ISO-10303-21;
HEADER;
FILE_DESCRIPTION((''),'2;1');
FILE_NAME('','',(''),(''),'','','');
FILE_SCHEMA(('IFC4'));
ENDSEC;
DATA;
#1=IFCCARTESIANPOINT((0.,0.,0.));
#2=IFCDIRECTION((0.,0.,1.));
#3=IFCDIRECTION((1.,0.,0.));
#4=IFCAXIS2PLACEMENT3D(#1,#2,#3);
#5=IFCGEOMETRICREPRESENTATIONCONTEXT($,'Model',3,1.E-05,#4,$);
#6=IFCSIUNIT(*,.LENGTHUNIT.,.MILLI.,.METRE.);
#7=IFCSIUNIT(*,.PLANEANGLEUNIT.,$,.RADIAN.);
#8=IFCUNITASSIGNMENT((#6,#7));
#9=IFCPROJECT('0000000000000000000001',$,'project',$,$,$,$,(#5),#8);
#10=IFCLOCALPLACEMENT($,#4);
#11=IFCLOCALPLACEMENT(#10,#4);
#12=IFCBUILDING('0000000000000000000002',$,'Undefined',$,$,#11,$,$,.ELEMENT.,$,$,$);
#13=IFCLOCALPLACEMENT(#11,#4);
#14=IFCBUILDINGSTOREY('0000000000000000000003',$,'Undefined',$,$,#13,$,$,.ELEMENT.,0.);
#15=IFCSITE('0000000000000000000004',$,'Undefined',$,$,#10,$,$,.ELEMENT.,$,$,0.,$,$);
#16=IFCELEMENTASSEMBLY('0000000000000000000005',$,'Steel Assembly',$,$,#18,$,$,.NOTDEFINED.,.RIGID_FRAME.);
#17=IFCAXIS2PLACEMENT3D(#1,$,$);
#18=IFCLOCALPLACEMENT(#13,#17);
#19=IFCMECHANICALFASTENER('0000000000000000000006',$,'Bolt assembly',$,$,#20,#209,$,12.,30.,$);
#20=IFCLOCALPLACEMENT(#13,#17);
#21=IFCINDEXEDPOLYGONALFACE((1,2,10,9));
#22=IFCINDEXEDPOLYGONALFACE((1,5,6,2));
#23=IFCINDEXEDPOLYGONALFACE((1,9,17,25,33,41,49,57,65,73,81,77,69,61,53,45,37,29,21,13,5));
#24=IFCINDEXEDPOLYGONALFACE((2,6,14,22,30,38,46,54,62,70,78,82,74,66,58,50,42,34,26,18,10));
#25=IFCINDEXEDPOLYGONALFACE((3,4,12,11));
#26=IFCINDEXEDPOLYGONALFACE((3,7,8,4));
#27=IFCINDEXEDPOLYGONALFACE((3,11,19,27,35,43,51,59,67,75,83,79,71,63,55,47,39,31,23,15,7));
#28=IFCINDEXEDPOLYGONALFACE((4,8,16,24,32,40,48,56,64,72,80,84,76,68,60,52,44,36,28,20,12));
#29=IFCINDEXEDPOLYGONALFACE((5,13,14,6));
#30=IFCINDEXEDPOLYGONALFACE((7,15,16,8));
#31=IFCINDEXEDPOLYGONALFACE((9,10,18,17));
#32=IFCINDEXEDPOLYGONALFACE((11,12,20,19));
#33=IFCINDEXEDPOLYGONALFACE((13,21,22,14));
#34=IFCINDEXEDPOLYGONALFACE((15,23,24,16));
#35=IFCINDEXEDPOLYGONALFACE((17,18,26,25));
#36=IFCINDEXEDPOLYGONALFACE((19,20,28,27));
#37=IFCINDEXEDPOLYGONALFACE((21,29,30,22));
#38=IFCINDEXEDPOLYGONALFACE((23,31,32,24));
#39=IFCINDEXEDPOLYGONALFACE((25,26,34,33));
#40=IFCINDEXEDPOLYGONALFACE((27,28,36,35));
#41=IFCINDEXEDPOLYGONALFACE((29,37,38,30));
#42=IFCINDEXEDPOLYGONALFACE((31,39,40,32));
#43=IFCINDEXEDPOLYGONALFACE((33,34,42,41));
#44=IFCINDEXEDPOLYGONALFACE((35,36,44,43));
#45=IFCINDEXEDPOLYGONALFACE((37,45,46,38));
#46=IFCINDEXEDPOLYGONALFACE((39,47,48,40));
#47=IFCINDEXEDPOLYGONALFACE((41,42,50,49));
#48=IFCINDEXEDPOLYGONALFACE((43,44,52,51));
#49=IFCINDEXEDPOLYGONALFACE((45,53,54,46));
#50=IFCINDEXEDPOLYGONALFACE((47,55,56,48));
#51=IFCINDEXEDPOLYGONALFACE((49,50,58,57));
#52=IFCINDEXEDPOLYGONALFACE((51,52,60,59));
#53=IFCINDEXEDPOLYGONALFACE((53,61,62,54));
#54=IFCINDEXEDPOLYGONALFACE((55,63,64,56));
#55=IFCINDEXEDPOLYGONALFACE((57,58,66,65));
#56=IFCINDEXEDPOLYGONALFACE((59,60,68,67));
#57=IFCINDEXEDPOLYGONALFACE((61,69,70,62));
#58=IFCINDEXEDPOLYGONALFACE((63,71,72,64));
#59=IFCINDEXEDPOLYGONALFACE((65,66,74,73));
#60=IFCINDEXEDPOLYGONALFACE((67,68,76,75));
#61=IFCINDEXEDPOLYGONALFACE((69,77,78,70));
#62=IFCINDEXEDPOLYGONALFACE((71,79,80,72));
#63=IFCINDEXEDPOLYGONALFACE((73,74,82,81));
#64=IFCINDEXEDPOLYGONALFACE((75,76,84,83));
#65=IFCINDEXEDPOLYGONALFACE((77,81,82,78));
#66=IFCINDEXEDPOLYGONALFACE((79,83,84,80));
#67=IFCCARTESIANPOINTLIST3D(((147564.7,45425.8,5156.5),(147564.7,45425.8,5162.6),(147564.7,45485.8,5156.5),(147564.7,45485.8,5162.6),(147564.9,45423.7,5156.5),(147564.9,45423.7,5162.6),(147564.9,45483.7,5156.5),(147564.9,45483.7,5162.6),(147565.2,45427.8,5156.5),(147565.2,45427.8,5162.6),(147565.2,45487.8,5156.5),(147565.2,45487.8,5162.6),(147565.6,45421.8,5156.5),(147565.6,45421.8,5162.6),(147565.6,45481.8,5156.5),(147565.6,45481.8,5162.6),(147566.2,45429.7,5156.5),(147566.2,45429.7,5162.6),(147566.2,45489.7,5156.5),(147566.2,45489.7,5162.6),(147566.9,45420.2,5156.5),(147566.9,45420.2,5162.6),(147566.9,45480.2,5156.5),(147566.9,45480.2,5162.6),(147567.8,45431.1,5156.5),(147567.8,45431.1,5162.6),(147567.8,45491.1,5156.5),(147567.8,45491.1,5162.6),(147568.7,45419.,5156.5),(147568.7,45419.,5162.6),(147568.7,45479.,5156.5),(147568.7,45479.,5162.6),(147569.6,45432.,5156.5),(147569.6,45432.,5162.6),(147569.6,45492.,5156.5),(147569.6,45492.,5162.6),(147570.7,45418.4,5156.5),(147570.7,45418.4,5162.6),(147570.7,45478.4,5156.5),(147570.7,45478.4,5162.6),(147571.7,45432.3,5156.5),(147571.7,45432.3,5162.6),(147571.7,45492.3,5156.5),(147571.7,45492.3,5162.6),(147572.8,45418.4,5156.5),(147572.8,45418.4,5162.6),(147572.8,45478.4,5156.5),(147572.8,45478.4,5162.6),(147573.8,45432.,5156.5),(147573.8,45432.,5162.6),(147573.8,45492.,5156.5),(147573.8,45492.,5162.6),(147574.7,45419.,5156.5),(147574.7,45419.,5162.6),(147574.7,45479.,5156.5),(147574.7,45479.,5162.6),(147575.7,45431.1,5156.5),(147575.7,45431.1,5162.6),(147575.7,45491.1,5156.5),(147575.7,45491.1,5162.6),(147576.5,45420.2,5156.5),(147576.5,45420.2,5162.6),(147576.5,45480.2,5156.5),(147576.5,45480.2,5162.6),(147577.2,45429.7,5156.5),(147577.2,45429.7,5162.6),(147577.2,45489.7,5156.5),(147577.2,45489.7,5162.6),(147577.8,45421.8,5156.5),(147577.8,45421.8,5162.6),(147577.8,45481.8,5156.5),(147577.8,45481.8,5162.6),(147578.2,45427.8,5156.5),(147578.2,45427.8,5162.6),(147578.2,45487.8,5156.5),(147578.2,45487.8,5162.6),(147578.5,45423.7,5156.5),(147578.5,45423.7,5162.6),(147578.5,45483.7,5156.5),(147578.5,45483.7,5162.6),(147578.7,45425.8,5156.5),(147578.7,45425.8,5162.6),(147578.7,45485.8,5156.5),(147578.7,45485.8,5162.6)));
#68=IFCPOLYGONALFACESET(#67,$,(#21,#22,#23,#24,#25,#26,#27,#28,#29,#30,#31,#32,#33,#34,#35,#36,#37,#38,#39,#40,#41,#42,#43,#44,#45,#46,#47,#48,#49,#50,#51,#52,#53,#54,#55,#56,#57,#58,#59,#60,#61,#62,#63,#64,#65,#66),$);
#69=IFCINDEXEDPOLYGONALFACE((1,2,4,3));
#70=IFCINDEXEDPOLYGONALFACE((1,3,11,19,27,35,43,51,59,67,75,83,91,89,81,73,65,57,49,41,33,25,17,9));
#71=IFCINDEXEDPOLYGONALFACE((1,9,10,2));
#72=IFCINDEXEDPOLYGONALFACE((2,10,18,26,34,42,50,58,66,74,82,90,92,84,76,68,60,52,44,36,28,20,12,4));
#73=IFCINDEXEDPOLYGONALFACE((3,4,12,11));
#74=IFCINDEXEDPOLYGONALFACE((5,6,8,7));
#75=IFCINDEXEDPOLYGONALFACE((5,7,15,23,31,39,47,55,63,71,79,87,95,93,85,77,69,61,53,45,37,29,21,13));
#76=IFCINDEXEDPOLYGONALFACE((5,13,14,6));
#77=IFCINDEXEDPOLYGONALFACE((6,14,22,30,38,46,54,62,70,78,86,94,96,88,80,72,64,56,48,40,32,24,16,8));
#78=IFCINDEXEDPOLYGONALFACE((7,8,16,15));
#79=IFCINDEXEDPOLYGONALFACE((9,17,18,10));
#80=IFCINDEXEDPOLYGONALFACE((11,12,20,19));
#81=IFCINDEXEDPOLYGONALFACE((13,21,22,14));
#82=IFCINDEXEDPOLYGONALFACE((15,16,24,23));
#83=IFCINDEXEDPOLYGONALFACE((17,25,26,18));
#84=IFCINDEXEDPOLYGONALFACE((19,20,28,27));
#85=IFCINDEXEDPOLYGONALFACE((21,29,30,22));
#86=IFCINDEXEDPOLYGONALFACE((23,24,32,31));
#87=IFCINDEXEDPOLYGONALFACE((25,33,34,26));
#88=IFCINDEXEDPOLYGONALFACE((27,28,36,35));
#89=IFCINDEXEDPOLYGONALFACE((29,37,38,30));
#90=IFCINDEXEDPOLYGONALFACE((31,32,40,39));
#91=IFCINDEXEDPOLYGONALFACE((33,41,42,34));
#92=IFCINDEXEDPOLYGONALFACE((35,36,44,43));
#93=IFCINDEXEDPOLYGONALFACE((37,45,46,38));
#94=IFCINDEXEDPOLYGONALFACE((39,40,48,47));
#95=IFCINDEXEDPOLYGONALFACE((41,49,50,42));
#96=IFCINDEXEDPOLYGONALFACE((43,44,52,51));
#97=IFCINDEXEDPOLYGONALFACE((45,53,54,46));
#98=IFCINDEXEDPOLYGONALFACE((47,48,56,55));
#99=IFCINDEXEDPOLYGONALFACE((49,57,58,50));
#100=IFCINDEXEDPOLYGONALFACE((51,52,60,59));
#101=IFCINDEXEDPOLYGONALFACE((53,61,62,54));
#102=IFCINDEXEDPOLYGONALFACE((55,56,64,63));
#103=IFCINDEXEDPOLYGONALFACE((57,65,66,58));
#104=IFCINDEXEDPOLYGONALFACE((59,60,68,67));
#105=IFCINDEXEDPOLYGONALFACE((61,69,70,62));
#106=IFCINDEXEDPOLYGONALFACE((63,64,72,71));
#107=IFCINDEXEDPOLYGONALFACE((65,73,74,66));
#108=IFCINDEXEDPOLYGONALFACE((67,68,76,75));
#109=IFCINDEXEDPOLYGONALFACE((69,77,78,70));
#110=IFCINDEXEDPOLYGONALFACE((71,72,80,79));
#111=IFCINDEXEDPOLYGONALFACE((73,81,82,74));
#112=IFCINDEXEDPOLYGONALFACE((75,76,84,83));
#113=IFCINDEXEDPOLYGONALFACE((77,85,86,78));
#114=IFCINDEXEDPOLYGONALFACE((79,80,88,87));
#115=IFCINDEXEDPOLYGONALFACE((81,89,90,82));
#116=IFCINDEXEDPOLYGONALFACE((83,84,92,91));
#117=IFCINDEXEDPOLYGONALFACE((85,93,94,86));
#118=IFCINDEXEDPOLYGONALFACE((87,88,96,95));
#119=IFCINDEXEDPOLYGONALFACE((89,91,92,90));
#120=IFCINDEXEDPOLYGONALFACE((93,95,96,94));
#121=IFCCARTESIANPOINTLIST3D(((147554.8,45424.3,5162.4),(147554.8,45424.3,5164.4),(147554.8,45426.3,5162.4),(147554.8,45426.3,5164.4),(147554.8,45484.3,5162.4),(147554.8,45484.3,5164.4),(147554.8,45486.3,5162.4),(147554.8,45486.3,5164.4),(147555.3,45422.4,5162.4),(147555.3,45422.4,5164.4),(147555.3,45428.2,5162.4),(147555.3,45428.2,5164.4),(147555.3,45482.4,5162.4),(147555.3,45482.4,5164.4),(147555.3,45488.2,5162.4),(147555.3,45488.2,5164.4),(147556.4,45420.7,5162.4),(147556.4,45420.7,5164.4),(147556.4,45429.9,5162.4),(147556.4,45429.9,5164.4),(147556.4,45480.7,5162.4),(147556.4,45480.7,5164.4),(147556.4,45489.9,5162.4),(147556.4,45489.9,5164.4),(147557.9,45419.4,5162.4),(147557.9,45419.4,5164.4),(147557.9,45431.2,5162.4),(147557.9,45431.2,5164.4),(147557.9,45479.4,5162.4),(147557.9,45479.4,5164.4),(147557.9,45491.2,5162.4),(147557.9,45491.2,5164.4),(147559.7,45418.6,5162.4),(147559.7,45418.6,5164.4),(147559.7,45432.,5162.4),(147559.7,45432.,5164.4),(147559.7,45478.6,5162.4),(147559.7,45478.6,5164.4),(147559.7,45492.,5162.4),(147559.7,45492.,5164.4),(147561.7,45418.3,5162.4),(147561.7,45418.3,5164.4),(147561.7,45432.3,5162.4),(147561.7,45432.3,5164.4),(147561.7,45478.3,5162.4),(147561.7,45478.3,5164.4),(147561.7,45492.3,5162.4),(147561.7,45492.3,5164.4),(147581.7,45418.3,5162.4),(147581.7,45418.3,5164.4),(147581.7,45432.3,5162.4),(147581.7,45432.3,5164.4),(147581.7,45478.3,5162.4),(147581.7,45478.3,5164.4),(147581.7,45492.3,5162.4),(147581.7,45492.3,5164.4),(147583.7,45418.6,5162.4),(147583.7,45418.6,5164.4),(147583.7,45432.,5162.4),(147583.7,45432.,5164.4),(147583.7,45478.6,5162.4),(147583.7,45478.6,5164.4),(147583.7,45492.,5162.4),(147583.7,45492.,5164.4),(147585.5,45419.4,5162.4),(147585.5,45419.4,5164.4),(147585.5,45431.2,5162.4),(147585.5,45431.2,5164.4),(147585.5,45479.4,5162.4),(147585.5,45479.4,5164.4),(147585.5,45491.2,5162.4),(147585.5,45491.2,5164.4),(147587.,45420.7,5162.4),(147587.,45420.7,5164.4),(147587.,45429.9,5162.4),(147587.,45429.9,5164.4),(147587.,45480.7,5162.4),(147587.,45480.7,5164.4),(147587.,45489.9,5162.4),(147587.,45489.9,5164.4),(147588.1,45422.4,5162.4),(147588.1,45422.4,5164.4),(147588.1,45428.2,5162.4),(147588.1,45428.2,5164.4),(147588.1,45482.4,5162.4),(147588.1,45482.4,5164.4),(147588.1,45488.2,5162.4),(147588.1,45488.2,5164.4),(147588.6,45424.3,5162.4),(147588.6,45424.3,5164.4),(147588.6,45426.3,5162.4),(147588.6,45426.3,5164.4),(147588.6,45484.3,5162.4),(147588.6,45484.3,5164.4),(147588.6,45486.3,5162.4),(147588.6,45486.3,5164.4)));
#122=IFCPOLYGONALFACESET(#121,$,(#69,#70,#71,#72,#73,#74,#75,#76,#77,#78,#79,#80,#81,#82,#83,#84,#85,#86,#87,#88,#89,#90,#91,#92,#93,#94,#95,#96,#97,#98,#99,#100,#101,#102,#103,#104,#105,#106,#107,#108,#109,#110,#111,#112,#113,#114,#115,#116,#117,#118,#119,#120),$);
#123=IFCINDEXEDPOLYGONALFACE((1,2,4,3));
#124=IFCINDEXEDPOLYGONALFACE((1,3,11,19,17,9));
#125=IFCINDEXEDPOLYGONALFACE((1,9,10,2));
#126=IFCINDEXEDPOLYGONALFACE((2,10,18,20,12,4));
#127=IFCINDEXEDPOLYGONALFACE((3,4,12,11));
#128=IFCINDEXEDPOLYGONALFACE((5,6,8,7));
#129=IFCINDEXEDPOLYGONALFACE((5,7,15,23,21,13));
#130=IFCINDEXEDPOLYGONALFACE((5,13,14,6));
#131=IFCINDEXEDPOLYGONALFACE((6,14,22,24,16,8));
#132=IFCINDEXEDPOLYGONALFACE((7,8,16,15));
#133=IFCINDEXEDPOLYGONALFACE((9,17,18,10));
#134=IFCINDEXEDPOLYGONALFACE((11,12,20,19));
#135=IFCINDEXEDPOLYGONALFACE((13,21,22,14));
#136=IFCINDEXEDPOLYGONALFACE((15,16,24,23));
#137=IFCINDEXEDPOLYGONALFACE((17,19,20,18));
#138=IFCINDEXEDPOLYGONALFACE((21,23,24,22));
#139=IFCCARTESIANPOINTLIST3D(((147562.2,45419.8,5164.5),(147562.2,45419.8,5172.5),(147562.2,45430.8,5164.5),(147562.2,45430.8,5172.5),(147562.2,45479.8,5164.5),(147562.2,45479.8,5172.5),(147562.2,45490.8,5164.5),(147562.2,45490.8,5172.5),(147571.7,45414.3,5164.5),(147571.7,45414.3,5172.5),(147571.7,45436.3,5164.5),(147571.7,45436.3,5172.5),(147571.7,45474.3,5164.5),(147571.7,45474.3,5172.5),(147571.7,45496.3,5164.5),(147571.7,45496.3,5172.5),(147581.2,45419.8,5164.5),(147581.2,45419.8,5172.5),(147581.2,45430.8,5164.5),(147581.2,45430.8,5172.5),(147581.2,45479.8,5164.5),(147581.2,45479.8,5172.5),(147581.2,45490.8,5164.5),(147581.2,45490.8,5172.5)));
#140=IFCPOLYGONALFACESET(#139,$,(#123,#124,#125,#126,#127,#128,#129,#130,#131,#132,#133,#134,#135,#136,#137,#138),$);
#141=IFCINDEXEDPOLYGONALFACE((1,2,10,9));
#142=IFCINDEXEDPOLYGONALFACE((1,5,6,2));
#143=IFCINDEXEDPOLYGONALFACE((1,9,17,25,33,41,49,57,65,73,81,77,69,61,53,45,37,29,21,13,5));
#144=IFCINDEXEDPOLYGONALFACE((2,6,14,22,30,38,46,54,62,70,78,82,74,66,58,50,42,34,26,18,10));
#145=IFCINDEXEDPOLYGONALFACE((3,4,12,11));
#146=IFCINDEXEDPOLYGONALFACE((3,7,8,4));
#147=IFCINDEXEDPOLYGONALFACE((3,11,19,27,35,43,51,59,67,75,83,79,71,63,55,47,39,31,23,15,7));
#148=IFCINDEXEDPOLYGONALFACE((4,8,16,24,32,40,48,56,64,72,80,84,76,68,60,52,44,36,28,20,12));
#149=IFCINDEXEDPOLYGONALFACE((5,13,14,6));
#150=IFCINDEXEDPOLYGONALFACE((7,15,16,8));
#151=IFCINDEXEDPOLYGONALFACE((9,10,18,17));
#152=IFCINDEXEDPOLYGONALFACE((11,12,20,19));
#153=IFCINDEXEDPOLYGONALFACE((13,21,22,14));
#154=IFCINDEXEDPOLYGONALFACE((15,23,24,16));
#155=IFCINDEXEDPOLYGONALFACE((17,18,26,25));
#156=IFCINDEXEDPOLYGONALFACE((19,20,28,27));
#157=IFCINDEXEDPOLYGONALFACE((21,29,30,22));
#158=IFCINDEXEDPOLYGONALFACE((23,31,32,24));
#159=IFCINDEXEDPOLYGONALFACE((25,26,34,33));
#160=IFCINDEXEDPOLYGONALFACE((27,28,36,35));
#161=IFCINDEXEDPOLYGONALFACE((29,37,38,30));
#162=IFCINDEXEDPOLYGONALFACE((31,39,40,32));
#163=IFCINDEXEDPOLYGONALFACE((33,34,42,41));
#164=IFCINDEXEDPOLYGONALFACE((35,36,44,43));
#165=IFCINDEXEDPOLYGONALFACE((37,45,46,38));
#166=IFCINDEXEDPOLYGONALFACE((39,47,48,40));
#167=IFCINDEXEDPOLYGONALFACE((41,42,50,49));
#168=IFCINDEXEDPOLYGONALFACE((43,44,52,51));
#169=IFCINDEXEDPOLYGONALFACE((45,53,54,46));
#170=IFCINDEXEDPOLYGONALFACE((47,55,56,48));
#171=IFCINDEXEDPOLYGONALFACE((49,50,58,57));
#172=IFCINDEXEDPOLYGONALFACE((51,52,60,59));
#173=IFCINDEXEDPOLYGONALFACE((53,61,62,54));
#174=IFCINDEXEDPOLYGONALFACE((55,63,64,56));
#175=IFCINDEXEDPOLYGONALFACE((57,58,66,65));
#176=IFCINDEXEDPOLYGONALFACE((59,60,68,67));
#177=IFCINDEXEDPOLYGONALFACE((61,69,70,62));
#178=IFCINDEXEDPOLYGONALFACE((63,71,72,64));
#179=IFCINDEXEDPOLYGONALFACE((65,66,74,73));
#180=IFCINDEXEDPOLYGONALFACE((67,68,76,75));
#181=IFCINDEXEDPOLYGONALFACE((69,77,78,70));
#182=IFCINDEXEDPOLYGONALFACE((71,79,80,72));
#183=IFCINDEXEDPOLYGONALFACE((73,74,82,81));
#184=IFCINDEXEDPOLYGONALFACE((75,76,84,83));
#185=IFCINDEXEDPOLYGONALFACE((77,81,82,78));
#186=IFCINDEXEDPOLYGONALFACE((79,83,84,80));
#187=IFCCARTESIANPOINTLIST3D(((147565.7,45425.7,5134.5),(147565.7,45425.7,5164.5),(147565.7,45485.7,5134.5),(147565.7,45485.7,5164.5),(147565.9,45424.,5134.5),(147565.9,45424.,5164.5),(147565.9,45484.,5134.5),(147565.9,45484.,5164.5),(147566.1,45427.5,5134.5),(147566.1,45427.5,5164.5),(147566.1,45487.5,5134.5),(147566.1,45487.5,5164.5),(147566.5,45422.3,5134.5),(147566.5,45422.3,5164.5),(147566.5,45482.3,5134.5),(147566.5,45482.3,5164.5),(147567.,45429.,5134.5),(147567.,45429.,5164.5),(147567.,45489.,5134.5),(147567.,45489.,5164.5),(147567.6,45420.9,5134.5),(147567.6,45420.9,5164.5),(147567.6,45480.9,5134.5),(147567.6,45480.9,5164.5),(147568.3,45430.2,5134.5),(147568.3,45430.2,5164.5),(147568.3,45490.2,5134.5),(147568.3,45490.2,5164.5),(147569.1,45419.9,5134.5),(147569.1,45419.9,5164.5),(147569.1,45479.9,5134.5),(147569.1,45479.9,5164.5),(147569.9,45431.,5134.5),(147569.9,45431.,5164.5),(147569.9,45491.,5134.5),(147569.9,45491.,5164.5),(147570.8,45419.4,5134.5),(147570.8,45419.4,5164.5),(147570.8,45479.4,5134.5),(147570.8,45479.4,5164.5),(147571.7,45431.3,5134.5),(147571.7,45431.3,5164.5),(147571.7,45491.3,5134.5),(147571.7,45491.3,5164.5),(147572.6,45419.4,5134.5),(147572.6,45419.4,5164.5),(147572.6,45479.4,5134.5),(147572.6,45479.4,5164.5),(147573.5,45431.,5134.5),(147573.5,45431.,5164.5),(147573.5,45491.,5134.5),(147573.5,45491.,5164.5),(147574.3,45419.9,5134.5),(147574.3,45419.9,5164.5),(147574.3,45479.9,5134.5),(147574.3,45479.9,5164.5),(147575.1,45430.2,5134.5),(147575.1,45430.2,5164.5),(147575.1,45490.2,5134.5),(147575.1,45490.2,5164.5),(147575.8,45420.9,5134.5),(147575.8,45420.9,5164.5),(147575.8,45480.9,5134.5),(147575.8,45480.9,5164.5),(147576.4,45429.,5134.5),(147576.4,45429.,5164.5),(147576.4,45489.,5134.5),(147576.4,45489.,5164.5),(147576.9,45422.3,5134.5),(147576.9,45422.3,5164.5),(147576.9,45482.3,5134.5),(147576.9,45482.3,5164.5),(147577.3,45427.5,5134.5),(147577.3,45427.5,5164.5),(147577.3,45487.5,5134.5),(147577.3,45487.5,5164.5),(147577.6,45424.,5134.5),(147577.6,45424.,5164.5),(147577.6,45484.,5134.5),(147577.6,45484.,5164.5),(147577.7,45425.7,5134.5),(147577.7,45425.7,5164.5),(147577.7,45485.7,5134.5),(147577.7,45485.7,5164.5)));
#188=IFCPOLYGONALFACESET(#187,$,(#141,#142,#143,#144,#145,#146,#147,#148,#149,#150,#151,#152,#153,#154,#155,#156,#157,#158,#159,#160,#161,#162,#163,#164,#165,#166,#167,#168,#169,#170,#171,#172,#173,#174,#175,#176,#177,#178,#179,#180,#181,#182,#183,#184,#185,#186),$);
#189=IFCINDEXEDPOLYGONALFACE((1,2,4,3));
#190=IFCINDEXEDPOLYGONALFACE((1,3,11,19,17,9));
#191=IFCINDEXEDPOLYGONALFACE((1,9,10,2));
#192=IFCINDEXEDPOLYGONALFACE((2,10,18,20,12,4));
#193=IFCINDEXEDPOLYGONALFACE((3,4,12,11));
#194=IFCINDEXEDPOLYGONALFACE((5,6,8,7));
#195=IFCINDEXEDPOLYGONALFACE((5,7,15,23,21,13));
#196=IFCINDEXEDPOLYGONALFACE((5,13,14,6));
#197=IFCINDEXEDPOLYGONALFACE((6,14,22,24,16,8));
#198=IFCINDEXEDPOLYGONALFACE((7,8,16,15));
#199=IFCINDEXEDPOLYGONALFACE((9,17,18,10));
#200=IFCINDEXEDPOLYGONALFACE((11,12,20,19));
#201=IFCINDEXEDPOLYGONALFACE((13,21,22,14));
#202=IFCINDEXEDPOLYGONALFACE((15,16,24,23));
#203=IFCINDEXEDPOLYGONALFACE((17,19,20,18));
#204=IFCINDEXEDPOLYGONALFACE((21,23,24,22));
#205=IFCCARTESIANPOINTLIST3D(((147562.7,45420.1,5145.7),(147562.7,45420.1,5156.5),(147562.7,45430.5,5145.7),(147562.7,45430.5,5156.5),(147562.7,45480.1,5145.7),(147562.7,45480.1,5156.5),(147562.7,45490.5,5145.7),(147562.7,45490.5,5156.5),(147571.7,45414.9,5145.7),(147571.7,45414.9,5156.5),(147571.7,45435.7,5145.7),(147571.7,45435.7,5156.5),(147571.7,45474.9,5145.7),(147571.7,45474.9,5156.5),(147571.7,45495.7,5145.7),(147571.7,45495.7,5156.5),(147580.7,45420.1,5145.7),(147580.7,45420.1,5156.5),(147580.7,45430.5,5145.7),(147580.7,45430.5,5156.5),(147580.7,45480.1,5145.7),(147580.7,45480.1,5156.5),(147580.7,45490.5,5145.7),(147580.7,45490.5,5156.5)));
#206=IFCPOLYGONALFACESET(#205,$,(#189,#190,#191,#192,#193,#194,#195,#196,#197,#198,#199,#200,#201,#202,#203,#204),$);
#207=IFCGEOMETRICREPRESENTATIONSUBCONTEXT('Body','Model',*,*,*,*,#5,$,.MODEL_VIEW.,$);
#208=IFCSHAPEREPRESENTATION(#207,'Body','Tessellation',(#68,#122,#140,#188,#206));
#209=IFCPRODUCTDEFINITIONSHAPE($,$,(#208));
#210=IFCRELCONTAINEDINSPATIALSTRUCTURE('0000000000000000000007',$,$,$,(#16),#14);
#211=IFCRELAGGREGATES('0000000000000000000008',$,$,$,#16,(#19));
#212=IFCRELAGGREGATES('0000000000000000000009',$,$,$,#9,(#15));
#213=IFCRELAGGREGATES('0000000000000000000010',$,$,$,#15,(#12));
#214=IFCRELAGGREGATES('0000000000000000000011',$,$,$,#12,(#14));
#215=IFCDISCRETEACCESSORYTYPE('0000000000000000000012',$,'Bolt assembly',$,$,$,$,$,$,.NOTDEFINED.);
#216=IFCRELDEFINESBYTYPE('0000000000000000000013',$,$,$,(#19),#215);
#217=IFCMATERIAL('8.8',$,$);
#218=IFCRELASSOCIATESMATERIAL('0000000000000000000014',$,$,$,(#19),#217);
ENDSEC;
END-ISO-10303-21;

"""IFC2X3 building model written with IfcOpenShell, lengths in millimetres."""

from ifc_helpers import new_model, si_unit, frame, frame_2d, origin_with_axes, origin_2d_with_axis, place, context, subcontext, project, spatial, polyline, circle_curve, parameter, trimmed, segment, composite_curve, circle, outline, extrude, source, transform, mapped, material, type_object, element, aggregate, save


model = new_model("IFC2X3")

# Units and contexts
model_context = context("Model", 3, precision=1e-05, world=origin_with_axes())
body_context = subcontext(model_context, "Body", "Model", "MODEL_VIEW")
ifc_project = project(units=[si_unit("LENGTHUNIT", "METRE", prefix="MILLI"), si_unit("PLANEANGLEUNIT", "RADIAN")], contexts=[model_context])

# Site, building, storey
site_placement = place(None, origin_with_axes())
site = spatial("IfcSite", under=ifc_project, at=site_placement, Name="Undefined", CompositionType="ELEMENT", RefElevation=0.0)
building_placement = place(site_placement, origin_with_axes())
building = spatial("IfcBuilding", under=site, at=building_placement, Name="Undefined", CompositionType="ELEMENT")
storey_placement = place(building_placement, origin_with_axes())
storey = spatial("IfcBuildingStorey", under=building, at=storey_placement, Name="Undefined", CompositionType="ELEMENT", Elevation=0.0)

# Element assembly
assembly_1_placement = place(storey_placement, origin_with_axes())
assembly_1 = element("IfcElementAssembly", 1, at=assembly_1_placement, inside=storey, Name="Steel Assembly", AssemblyPlace="NOTDEFINED", PredefinedType="RIGID_FRAME")

# Shared definitions
discrete_accessory_type_1 = type_object("IfcDiscreteAccessoryType", Name="Bolt assembly")
ifc_material_1 = material(Name="8.8")

# Mechanical fastener
shared_shape_1 = source(origin_with_axes(), body_context, "Body", "SweptSolid", [
    extrude(circle(Radius=7.0, at=origin_2d_with_axis()), frame((0.0, -3.1, 0.0), z_axis=(0.0, 1.0, 0.0), x_axis=(1.0, 0.0, 0.0)), (0.0, 0.0, 1.0), 6.1),
    extrude(outline(composite_curve([segment(polyline([(7.0, 10.0), (7.0, -10.0)]), True, "CONTINUOUS"), segment(trimmed(circle_curve(frame_2d((0.0, -10.0), x_axis=(1.0, 0.0)), 7.0), [parameter(0.0)], [parameter(3.1416)], False, "PARAMETER"), True, "CONTINUOUS"), segment(polyline([(-7.0, -10.0), (-7.0, 10.0)]), True, "CONTINUOUS"), segment(trimmed(circle_curve(frame_2d((0.0, 10.0), x_axis=(-1.0, 0.0)), 7.0), [parameter(0.0)], [parameter(3.1416)], False, "PARAMETER"), True, "DISCONTINUOUS")], self_intersect=False)), frame((0.0, -4.9, 0.0), z_axis=(0.0, 1.0, 0.0), x_axis=(1.0, 0.0, 0.0)), (0.0, 0.0, 1.0), 2.0),
    extrude(outline(polyline([(11.0, 0.0), (5.5, 9.5), (-5.5, 9.5), (-11.0, 0.0), (-5.5, -9.5), (5.5, -9.5), (11.0, 0.0)])), frame((0.0, -13.0, 0.0), z_axis=(0.0, 1.0, 0.0), x_axis=(1.0, 0.0, 0.0)), (0.0, 0.0, 1.0), 8.0),
    extrude(circle(Radius=6.0, at=origin_2d_with_axis()), frame((0.0, -5.0, 0.0), z_axis=(0.0, 1.0, 0.0), x_axis=(1.0, 0.0, 0.0)), (0.0, 0.0, 1.0), 30.0),
    extrude(outline(polyline([(10.4, 0.0), (5.2, 9.0), (-5.2, 9.0), (-10.4, 0.0), (-5.2, -9.0), (5.2, -9.0), (10.4, 0.0)])), frame((0.0, 3.0, 0.0), z_axis=(0.0, 1.0, 0.0), x_axis=(1.0, 0.0, 0.0)), (0.0, 0.0, 1.0), 10.8),
])
mechanical_fastener_1_placement = place(assembly_1_placement, frame((147616.7, 45380.3, 5159.5), z_axis=(-1.0, 0.0, 0.0), x_axis=(0.0, 1.0, 0.0)))
mechanical_fastener_1 = element("IfcMechanicalFastener", 2, at=mechanical_fastener_1_placement, type_object=discrete_accessory_type_1, material=ifc_material_1, Name="Bolt assembly", NominalDiameter=12.0, NominalLength=30.0, context=body_context, shape_type="MappedRepresentation", body=[
    mapped(shared_shape_1, transform((45.0, 0.0, 45.0))),
    mapped(shared_shape_1, transform((105.0, 0.0, 45.0))),
])
aggregate(assembly_1, [mechanical_fastener_1])

save(model, "model.ifc")
